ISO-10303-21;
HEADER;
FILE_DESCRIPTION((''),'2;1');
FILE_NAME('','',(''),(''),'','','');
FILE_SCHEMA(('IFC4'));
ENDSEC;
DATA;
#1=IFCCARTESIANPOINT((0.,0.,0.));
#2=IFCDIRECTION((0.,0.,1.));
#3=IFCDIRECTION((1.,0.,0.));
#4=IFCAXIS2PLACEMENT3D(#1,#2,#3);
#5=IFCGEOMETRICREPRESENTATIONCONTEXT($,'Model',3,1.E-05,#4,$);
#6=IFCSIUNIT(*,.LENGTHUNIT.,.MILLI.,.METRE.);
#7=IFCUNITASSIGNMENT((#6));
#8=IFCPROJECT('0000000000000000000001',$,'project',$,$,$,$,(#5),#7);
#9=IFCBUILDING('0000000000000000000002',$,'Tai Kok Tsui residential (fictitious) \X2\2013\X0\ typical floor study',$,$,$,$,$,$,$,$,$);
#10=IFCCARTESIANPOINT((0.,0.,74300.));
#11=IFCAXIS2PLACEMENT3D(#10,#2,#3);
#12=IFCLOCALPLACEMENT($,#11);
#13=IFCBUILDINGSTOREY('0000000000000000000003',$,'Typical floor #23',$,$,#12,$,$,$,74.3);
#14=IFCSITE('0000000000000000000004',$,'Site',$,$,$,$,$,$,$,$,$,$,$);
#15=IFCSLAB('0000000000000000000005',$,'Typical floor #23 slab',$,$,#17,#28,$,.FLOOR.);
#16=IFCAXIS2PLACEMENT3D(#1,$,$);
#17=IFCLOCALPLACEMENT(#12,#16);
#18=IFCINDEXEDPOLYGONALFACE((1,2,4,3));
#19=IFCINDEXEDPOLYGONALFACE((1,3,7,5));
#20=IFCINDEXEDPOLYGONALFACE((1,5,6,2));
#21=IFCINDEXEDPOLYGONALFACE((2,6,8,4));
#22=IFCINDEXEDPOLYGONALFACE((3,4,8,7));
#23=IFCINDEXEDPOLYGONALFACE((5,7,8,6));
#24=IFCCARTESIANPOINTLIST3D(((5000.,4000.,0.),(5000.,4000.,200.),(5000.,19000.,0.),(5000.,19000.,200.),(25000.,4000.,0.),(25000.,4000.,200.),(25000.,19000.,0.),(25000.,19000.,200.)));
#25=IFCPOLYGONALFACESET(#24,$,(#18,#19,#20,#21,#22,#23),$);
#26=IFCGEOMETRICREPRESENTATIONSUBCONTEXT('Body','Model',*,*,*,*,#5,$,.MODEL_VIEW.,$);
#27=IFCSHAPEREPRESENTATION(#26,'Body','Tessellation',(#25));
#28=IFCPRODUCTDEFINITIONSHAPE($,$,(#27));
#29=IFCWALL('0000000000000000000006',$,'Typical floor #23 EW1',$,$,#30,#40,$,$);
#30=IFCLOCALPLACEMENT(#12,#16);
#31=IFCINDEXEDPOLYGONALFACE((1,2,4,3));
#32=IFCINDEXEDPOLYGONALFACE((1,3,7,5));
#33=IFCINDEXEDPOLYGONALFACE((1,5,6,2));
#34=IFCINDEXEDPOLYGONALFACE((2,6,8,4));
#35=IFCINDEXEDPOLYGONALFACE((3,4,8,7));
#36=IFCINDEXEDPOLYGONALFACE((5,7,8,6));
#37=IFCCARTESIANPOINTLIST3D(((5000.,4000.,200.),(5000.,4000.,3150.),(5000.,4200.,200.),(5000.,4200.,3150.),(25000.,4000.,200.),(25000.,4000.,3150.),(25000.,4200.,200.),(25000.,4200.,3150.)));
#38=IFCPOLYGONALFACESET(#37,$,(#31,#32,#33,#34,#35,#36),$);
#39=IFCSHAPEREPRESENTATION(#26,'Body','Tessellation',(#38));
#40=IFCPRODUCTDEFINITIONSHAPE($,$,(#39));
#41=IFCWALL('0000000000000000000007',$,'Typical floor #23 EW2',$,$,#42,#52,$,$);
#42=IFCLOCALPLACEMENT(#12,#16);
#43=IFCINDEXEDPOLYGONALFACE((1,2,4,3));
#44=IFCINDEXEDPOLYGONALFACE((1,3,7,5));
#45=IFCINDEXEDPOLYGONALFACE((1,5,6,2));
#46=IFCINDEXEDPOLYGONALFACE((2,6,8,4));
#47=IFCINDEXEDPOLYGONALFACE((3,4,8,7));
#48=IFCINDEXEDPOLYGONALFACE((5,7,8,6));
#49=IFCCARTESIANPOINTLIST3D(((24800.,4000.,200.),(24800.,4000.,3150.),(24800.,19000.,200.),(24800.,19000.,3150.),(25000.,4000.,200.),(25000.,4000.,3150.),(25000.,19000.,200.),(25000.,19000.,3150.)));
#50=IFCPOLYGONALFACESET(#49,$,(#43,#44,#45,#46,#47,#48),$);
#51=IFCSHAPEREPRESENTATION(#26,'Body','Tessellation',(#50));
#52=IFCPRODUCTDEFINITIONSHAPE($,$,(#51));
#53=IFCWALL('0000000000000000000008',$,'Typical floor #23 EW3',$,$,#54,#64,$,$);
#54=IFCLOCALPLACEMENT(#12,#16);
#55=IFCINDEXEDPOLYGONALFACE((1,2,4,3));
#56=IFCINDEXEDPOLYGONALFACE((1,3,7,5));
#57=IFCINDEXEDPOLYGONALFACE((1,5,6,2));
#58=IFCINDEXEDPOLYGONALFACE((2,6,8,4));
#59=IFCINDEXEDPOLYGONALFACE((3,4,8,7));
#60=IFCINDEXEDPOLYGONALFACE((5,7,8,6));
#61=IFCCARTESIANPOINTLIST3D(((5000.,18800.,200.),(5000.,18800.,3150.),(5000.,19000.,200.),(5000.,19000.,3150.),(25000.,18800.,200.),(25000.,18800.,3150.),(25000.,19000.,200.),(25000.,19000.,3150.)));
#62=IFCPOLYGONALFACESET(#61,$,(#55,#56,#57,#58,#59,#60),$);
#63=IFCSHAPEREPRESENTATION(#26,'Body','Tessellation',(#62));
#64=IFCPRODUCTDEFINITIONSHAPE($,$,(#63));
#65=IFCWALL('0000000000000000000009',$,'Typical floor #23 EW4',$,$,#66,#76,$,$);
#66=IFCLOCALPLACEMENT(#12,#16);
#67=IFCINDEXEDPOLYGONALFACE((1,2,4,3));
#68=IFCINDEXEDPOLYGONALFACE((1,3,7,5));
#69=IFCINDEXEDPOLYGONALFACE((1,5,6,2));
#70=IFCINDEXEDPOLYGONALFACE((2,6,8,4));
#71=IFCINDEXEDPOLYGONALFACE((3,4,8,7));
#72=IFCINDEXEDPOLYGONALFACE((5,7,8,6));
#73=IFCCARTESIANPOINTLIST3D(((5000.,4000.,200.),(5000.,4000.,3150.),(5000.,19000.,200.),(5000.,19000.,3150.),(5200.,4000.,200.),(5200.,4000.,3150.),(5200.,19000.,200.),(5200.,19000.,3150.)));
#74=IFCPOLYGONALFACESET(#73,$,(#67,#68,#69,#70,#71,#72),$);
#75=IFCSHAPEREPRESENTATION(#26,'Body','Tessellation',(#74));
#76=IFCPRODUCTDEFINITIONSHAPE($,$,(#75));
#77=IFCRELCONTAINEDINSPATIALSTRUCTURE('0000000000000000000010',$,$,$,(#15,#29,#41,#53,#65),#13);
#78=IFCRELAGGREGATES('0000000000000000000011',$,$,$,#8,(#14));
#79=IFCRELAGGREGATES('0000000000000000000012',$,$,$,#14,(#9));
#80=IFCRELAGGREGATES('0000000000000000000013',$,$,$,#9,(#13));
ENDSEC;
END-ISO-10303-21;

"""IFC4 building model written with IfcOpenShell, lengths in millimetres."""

from ifc_helpers import new_model, si_unit, frame, origin_with_axes, place, context, subcontext, project, spatial, indexed_curve, outline, extrude, element, save


model = new_model("IFC4")

# Units and contexts
model_context = context("Model", 3, precision=1e-05, world=origin_with_axes())
body_context = subcontext(model_context, "Body", "Model", "MODEL_VIEW")
ifc_project = project(units=[si_unit("LENGTHUNIT", "METRE", prefix="MILLI")], contexts=[model_context])

# Site, building, storey
site = spatial("IfcSite", under=ifc_project, Name="Site")
building = spatial("IfcBuilding", under=site, Name="Tai Kok Tsui residential (fictitious) – typical floor study")
storey_placement = place(None, frame((0.0, 0.0, 74300.0), z_axis=(0.0, 0.0, 1.0), x_axis=(1.0, 0.0, 0.0)))
storey = spatial("IfcBuildingStorey", under=building, at=storey_placement, Name="Typical floor #23", Elevation=74.3)

# Slab
slab_placement = place(storey_placement, origin_with_axes())
element("IfcSlab", 1, at=slab_placement, inside=storey, Name="Typical floor #23 slab", PredefinedType="FLOOR", context=body_context, shape_type="SweptSolid", body=[
    extrude(outline(indexed_curve([(5000.0, 4000.0), (25000.0, 4000.0), (25000.0, 19000.0), (5000.0, 19000.0)])), None, (0.0, 0.0, 1.0), 200.0),
])

# Walls
wall_1_placement = place(storey_placement, frame((5000.0, 4000.0, 200.0), z_axis=(0.0, 0.0, 1.0), x_axis=(1.0, 0.0, 0.0)))
element("IfcWall", 2, at=wall_1_placement, inside=storey, Name="Typical floor #23 EW1", context=body_context, shape_type="SweptSolid", body=[
    extrude(outline(indexed_curve([(0.0, 0.0), (0.0, 200.0), (20000.0, 200.0), (20000.0, 0.0), (0.0, 0.0)], self_intersect=False)), origin_with_axes(), (0.0, 0.0, 1.0), 2950.0),
])
wall_2_placement = place(storey_placement, frame((25000.0, 4000.0, 200.0), z_axis=(0.0, 0.0, 1.0), x_axis=(0.0, 1.0, 0.0)))
element("IfcWall", 3, at=wall_2_placement, inside=storey, Name="Typical floor #23 EW2", context=body_context, shape_type="SweptSolid", body=[
    extrude(outline(indexed_curve([(0.0, 0.0), (0.0, 200.0), (15000.0, 200.0), (15000.0, 0.0), (0.0, 0.0)], self_intersect=False)), origin_with_axes(), (0.0, 0.0, 1.0), 2950.0),
])
wall_3_placement = place(storey_placement, frame((25000.0, 19000.0, 200.0), z_axis=(0.0, 0.0, 1.0), x_axis=(-1.0, 0.0, 0.0)))
element("IfcWall", 4, at=wall_3_placement, inside=storey, Name="Typical floor #23 EW3", context=body_context, shape_type="SweptSolid", body=[
    extrude(outline(indexed_curve([(0.0, 0.0), (0.0, 200.0), (20000.0, 200.0), (20000.0, 0.0), (0.0, 0.0)], self_intersect=False)), origin_with_axes(), (0.0, 0.0, 1.0), 2950.0),
])
wall_4_placement = place(storey_placement, frame((5000.0, 19000.0, 200.0), z_axis=(0.0, 0.0, 1.0), x_axis=(0.0, -1.0, 0.0)))
element("IfcWall", 5, at=wall_4_placement, inside=storey, Name="Typical floor #23 EW4", context=body_context, shape_type="SweptSolid", body=[
    extrude(outline(indexed_curve([(0.0, 0.0), (0.0, 200.0), (15000.0, 200.0), (15000.0, 0.0), (0.0, 0.0)], self_intersect=False)), origin_with_axes(), (0.0, 0.0, 1.0), 2950.0),
])

save(model, "model.ifc")
